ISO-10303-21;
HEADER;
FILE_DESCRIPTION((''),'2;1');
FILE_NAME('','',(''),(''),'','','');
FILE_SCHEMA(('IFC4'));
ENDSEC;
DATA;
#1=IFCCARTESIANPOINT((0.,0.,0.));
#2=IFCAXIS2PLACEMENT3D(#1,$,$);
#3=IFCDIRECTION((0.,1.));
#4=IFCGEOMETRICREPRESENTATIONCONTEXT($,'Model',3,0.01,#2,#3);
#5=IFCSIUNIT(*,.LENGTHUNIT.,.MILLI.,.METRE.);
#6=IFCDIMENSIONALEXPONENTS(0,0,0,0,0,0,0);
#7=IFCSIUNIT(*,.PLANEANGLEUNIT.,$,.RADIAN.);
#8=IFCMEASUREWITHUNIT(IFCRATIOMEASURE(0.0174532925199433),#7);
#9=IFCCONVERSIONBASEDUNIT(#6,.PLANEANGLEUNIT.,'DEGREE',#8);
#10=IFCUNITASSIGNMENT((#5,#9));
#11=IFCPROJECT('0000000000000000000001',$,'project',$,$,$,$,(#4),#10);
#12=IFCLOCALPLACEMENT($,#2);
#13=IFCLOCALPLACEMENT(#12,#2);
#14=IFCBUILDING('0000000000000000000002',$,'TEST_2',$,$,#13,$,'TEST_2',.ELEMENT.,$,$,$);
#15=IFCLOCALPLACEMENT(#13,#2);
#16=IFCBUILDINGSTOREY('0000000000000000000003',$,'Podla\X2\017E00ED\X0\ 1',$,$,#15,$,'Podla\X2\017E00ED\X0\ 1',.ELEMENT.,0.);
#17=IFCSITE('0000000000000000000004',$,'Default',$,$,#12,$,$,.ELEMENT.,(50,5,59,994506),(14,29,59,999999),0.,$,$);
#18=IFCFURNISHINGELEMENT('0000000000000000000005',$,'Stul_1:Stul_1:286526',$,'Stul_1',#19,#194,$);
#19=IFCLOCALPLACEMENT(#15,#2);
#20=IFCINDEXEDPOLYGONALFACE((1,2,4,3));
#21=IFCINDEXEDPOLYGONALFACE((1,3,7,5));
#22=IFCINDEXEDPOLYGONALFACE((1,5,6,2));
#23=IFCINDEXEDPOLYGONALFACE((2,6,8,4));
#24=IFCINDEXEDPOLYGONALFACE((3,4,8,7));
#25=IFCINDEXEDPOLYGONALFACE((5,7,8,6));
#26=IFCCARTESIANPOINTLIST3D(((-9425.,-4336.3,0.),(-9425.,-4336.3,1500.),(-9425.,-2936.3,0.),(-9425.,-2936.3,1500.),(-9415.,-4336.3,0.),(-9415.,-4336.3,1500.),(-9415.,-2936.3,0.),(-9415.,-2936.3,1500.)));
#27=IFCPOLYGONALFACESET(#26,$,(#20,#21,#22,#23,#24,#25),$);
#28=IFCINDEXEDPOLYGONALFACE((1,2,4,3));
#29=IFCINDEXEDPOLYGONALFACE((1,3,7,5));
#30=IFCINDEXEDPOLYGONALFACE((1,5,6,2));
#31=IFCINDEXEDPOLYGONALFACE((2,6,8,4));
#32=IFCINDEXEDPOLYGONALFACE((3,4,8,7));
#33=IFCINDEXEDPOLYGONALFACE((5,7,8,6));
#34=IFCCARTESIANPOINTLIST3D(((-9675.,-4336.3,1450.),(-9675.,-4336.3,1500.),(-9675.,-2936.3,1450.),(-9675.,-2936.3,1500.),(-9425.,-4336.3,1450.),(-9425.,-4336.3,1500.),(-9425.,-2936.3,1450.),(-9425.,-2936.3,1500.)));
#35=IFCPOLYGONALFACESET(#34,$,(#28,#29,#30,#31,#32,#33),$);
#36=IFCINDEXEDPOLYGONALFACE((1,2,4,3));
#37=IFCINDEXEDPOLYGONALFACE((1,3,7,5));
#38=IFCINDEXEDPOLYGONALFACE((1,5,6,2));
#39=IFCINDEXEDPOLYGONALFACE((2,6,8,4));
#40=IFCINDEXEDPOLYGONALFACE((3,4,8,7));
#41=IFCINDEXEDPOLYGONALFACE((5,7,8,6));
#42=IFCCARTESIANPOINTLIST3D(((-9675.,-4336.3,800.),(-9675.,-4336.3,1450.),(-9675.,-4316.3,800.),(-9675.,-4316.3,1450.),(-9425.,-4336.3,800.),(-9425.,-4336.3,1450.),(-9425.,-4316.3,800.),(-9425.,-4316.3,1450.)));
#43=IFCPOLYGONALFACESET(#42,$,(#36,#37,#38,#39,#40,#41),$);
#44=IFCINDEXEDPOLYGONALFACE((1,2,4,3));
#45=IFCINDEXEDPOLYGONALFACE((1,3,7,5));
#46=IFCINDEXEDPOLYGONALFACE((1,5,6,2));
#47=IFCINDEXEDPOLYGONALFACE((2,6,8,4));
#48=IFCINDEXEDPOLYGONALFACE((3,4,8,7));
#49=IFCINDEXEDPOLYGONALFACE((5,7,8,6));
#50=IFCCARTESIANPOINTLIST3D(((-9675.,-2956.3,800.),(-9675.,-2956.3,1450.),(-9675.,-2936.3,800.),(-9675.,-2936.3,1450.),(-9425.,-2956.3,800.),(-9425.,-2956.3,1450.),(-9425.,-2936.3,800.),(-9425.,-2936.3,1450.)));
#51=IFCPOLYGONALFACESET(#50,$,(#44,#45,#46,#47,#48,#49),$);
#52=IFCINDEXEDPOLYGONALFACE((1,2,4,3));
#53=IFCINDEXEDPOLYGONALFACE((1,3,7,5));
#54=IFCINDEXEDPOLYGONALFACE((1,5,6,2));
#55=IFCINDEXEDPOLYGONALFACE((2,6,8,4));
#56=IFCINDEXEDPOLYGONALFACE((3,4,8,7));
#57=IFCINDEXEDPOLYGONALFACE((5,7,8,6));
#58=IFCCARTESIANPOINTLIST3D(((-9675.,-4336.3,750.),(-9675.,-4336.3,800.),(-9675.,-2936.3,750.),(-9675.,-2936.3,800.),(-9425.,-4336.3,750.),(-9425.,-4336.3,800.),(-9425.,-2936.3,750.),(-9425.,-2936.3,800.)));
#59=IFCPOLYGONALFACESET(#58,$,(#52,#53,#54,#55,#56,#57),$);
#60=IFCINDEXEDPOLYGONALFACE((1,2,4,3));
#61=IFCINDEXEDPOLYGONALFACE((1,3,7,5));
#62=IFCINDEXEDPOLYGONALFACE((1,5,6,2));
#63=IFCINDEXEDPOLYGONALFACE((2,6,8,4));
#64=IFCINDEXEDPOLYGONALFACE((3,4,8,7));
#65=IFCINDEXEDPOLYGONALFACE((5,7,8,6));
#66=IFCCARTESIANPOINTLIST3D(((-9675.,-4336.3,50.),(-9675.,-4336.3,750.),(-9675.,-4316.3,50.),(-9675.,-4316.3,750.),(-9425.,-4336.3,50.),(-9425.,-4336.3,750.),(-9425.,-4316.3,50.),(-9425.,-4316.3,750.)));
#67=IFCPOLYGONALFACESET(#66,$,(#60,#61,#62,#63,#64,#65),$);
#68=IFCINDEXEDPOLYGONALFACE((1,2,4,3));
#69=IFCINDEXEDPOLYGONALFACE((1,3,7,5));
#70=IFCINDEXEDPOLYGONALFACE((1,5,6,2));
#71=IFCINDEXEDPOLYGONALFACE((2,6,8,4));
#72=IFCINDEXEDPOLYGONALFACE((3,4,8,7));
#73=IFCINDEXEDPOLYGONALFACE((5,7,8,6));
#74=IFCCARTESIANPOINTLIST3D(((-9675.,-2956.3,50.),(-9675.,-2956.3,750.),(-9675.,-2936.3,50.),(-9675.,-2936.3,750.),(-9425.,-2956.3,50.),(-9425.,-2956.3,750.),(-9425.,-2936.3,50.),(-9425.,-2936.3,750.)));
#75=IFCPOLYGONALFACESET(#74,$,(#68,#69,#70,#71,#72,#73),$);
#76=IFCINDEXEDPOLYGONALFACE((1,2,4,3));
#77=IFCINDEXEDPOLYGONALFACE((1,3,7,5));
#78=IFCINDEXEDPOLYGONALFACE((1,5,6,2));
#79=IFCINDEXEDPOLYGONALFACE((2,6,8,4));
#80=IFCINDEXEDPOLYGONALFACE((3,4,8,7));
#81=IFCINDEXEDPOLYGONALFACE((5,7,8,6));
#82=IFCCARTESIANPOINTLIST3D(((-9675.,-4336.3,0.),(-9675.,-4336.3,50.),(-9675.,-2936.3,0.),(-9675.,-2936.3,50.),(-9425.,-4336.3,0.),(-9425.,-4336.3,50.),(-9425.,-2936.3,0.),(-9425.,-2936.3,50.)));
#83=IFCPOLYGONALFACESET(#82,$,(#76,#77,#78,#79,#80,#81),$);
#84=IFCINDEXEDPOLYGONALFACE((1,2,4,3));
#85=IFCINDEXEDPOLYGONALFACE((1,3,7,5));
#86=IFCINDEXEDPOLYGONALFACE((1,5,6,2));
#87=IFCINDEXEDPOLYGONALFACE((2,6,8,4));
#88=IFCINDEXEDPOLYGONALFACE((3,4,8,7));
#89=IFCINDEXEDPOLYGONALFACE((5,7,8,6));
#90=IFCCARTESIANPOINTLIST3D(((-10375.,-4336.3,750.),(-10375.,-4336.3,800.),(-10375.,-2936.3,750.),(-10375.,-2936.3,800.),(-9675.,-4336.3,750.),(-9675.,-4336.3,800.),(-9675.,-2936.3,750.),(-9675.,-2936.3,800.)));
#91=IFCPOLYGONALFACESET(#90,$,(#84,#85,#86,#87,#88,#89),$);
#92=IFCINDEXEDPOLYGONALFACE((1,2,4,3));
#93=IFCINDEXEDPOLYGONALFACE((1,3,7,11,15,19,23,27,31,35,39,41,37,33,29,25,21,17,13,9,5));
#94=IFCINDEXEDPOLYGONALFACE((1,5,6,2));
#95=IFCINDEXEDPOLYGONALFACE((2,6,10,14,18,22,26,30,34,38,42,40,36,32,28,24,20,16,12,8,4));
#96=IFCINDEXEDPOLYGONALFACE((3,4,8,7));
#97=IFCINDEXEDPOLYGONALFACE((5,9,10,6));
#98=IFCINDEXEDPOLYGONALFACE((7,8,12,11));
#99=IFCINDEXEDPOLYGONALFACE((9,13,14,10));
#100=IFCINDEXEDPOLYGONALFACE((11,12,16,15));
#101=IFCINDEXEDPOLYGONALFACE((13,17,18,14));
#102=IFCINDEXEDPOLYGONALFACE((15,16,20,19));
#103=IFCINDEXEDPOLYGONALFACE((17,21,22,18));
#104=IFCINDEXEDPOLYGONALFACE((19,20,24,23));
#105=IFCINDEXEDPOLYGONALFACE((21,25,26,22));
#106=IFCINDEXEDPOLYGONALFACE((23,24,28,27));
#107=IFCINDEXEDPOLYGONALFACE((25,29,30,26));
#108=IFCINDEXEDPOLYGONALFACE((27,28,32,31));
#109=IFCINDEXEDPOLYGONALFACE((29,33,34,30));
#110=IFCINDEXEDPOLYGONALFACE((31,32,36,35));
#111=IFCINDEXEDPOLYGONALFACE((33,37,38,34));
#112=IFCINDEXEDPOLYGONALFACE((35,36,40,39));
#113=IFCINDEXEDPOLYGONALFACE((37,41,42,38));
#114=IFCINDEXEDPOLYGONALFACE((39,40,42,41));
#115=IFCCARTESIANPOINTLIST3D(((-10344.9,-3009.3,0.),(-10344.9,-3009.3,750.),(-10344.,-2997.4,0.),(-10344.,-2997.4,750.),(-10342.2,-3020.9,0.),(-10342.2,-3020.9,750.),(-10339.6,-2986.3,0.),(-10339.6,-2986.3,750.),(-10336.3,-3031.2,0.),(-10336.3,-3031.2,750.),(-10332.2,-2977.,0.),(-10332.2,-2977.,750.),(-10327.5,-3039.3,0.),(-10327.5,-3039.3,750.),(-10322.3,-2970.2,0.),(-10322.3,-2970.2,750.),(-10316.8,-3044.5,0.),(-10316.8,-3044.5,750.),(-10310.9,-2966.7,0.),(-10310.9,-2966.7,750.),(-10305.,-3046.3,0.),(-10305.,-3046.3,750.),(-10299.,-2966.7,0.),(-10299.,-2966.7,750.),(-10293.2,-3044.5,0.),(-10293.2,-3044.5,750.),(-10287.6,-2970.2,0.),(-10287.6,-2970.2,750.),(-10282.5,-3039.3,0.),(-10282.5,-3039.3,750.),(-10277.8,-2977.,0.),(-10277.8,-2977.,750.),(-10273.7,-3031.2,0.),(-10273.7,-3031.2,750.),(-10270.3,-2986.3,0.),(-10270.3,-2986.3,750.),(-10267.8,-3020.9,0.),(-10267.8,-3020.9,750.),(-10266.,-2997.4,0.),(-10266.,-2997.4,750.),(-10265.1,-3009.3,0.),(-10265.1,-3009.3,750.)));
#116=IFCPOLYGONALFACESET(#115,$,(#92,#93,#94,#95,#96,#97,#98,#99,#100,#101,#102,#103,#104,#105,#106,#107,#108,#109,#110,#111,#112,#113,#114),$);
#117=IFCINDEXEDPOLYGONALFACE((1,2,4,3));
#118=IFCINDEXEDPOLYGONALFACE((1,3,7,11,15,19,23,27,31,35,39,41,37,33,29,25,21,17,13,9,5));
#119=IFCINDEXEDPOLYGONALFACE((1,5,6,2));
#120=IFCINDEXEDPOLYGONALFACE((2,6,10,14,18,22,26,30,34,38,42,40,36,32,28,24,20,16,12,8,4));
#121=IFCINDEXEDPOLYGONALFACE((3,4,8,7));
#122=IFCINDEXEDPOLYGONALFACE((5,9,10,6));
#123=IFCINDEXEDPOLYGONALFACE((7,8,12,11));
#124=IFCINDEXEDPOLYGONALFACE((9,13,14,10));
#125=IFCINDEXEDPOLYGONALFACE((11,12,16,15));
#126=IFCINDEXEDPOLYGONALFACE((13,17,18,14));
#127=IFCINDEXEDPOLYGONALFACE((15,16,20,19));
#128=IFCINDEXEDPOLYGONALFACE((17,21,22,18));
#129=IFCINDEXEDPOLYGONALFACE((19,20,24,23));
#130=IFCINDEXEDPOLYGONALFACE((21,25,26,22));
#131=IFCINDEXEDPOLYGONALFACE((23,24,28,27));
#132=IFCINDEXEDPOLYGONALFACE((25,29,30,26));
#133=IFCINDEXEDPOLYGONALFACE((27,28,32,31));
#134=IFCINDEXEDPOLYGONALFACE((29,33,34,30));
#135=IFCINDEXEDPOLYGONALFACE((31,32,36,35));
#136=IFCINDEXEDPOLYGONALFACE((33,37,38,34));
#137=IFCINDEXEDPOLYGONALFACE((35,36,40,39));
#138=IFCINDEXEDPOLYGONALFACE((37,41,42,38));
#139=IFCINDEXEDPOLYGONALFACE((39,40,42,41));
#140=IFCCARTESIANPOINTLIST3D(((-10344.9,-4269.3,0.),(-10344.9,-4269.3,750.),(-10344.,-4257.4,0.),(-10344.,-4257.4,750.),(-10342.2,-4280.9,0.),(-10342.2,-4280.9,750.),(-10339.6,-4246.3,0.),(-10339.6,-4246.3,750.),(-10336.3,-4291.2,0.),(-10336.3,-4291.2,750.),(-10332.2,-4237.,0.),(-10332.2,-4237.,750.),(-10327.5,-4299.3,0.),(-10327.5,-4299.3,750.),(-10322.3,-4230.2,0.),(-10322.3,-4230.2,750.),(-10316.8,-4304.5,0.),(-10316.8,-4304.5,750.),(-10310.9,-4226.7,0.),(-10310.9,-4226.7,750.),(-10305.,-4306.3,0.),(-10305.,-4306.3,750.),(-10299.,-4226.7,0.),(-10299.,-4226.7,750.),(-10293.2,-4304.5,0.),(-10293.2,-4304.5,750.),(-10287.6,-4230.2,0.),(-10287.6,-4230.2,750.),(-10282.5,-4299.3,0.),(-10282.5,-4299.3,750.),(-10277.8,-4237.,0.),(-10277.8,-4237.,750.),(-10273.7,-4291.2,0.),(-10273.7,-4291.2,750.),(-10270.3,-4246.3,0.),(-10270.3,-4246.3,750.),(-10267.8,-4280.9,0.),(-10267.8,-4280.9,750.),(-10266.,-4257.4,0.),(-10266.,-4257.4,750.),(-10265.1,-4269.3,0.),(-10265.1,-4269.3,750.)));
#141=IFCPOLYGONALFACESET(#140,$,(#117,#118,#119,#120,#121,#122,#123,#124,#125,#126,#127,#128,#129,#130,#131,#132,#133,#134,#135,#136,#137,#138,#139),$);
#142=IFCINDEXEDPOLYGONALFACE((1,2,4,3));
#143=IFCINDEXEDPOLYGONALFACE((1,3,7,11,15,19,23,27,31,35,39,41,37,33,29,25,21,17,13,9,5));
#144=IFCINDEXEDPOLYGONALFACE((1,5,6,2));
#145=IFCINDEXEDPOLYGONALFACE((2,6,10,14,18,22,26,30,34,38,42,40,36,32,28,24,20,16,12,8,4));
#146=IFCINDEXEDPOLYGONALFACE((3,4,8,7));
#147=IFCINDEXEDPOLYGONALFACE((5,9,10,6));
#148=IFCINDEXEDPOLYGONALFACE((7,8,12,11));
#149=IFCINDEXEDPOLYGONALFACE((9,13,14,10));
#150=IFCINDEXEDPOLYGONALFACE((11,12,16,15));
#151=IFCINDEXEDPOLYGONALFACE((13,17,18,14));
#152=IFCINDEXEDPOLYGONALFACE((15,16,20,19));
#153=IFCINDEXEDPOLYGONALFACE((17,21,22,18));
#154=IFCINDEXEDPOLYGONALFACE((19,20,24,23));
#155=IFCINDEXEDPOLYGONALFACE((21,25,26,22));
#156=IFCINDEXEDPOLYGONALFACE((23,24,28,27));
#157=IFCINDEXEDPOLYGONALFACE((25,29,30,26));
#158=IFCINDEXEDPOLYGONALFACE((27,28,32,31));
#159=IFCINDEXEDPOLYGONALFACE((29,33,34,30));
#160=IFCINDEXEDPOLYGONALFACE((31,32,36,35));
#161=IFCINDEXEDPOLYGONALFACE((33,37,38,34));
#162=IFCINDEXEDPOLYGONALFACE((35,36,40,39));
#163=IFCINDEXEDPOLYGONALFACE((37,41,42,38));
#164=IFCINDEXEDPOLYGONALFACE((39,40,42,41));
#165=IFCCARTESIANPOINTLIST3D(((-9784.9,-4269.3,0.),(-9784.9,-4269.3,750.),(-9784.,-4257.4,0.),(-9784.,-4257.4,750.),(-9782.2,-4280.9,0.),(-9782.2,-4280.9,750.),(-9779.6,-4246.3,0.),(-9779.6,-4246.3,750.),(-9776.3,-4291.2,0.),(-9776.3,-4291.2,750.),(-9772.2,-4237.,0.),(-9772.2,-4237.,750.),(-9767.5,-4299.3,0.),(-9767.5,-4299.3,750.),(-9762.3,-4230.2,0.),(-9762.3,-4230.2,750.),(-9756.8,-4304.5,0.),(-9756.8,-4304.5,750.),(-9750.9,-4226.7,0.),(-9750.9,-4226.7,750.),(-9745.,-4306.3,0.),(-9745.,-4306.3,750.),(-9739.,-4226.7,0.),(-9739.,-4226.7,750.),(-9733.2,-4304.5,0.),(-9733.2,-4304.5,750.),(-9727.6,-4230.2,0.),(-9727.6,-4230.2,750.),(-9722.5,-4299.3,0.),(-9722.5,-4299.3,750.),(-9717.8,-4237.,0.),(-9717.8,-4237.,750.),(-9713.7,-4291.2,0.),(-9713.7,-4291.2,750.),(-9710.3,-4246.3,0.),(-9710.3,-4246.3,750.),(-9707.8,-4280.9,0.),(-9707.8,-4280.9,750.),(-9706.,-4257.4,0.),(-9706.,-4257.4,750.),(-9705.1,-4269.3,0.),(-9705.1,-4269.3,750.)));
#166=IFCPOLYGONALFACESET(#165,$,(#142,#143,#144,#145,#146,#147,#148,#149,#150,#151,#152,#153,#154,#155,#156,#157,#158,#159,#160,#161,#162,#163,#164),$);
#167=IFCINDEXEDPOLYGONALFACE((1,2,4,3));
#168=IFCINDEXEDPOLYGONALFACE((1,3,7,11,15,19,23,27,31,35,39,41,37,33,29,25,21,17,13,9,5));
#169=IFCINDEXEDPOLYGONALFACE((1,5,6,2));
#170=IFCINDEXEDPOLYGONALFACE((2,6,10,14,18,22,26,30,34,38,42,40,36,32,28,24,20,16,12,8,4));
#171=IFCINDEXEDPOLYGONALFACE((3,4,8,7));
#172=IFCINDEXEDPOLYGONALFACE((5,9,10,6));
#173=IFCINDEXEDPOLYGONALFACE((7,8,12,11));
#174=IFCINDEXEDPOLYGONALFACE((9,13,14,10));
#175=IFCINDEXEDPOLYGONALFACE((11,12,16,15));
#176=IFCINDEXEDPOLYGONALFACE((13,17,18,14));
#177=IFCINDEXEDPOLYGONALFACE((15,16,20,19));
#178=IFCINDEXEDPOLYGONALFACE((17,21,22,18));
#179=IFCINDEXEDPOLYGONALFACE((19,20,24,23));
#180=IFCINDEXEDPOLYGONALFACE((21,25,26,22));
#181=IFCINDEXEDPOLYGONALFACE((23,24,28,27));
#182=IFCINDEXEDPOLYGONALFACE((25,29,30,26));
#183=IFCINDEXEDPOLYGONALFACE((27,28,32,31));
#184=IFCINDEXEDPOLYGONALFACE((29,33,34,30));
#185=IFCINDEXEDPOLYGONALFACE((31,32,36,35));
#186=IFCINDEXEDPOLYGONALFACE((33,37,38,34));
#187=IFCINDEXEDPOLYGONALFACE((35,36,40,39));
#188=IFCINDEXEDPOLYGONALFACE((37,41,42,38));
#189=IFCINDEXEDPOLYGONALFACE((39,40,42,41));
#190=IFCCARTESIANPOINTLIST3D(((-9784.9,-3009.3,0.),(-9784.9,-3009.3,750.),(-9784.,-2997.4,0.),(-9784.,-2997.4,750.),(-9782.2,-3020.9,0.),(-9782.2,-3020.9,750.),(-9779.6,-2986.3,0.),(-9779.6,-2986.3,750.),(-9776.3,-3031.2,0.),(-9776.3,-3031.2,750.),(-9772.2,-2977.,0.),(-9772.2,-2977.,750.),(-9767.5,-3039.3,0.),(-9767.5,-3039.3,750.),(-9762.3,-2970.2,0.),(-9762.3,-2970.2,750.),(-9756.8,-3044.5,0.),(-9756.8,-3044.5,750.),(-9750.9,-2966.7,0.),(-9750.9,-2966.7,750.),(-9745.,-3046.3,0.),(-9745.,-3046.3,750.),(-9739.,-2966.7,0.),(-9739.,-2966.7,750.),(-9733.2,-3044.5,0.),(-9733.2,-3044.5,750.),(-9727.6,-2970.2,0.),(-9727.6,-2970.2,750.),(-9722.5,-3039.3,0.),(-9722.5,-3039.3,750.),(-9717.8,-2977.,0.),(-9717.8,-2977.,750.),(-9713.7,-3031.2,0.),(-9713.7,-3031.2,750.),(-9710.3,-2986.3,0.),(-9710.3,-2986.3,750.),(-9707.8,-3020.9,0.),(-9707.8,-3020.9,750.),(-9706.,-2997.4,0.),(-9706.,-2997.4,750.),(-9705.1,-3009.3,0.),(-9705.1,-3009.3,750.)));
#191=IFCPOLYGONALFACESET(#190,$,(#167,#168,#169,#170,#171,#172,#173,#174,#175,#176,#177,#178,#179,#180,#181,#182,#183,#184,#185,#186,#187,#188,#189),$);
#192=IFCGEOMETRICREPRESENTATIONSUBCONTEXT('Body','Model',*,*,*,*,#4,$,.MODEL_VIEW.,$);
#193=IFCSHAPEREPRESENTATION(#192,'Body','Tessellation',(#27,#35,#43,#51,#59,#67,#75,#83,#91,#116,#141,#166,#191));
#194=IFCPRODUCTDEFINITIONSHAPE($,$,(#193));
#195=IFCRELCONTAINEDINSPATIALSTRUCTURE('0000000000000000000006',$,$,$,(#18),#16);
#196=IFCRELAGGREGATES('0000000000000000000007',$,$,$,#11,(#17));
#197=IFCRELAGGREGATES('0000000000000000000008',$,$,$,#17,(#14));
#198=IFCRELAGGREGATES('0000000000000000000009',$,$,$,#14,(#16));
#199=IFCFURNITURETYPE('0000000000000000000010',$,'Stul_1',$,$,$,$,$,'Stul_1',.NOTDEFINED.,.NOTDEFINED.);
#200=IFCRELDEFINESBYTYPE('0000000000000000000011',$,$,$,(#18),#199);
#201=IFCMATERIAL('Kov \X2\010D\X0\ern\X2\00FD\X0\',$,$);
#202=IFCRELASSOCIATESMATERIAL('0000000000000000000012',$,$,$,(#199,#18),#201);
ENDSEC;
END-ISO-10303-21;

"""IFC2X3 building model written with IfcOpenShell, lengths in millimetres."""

from ifc_helpers import new_model, entity, si_unit, converted_unit, direction, frame, frame_2d, origin, origin_2d_with_axis, place, context, subcontext, project, spatial, rectangle, circle, extrude, source, transform, mapped, material, type_object, type_shapes, element, save


model = new_model("IFC2X3")

# Units and contexts
model_context = context("Model", 3, precision=0.01, world=origin(), true_north=direction((0.0, 1.0)))
body_context = subcontext(model_context, "Body", "Model", "MODEL_VIEW")
ifc_project = project(units=[si_unit("LENGTHUNIT", "METRE", prefix="MILLI"), converted_unit("PLANEANGLEUNIT", "DEGREE", entity("IfcRatioMeasure", 0.0174532925199433), si_unit("PLANEANGLEUNIT", "RADIAN"), dimensions=[0, 0, 0, 0, 0, 0, 0])], contexts=[model_context])

# Site, building, storey
site_placement = place(None, origin())
site = spatial("IfcSite", under=ifc_project, at=site_placement, Name="Default", CompositionType="ELEMENT", RefLatitude=(50, 5, 59, 994506), RefLongitude=(14, 29, 59, 999999), RefElevation=0.0)
building_placement = place(site_placement, origin())
building = spatial("IfcBuilding", under=site, at=building_placement, Name="TEST_2", LongName="TEST_2", CompositionType="ELEMENT")
storey_placement = place(building_placement, origin())
storey = spatial("IfcBuildingStorey", under=building, at=storey_placement, Name="Podlaží 1", LongName="Podlaží 1", CompositionType="ELEMENT", Elevation=0.0)

# Furnishing element
ifc_material_1 = material(Name="Kov černý")
furniture_type = type_object("IfcFurnitureType", Name="Stul_1", ElementType="Stul_1", material=ifc_material_1)
shared_shape_1 = source(origin(), body_context, "Body", "SweptSolid", [
    extrude(rectangle(XDim=1400.0, YDim=10.0, at=origin_2d_with_axis()), frame((0.0, 605.0, 0.0), z_axis=(0.0, 0.0, 1.0), x_axis=(-1.0, 0.0, 0.0)), (0.0, 0.0, 1.0), 1500.0),
    extrude(rectangle(XDim=1400.0, YDim=250.0, at=frame_2d((0.0, 0.0), x_axis=(1.0, 0.0))), frame((0.0, 475.0, 1450.0), z_axis=(0.0, 0.0, 1.0), x_axis=(-1.0, 0.0, 0.0)), (0.0, 0.0, 1.0), 50.0),
    extrude(rectangle(XDim=20.0, YDim=250.0, at=origin_2d_with_axis()), frame((690.0, 475.0, 800.0), z_axis=(0.0, 0.0, 1.0), x_axis=(-1.0, 0.0, 0.0)), (0.0, 0.0, 1.0), 650.0),
    extrude(rectangle(XDim=20.0, YDim=250.0, at=frame_2d((0.0, 0.0), x_axis=(1.0, 0.0))), frame((-690.0, 475.0, 800.0), z_axis=(0.0, 0.0, 1.0), x_axis=(-1.0, 0.0, 0.0)), (0.0, 0.0, 1.0), 650.0),
    extrude(rectangle(XDim=1400.0, YDim=250.0, at=origin_2d_with_axis()), frame((0.0, 475.0, 750.0), z_axis=(0.0, 0.0, 1.0), x_axis=(-1.0, 0.0, 0.0)), (0.0, 0.0, 1.0), 50.0),
    extrude(rectangle(XDim=20.0, YDim=250.0, at=origin_2d_with_axis()), frame((690.0, 475.0, 50.0), z_axis=(0.0, 0.0, 1.0), x_axis=(-1.0, 0.0, 0.0)), (0.0, 0.0, 1.0), 700.0),
    extrude(rectangle(XDim=20.0, YDim=250.0, at=frame_2d((0.0, 0.0), x_axis=(1.0, 0.0))), frame((-690.0, 475.0, 50.0), z_axis=(0.0, 0.0, 1.0), x_axis=(-1.0, 0.0, 0.0)), (0.0, 0.0, 1.0), 700.0),
    extrude(rectangle(XDim=1400.0, YDim=250.0, at=origin_2d_with_axis()), frame((0.0, 475.0, 0.0), z_axis=(0.0, 0.0, 1.0), x_axis=(-1.0, 0.0, 0.0)), (0.0, 0.0, 1.0), 50.0),
    extrude(rectangle(XDim=1400.0, YDim=700.0, at=origin_2d_with_axis()), frame((0.0, 0.0, 750.0), z_axis=(0.0, 0.0, 1.0), x_axis=(-1.0, 0.0, 0.0)), (0.0, 0.0, 1.0), 50.0),
    extrude(circle(Radius=40.0, at=frame_2d((0.0, 0.0), x_axis=(1.0, 0.0))), frame((-630.0, -280.0, 0.0)), (0.0, 0.0, 1.0), 750.0),
    extrude(circle(Radius=40.0, at=frame_2d((0.0, 0.0), x_axis=(1.0, 0.0))), frame((630.0, -280.0, 0.0)), (0.0, 0.0, 1.0), 750.0),
    extrude(circle(Radius=40.0, at=frame_2d((0.0, 0.0), x_axis=(1.0, 0.0))), frame((630.0, 280.0, 0.0)), (0.0, 0.0, 1.0), 750.0),
    extrude(circle(Radius=40.0, at=frame_2d((0.0, 0.0), x_axis=(1.0, 0.0))), frame((-630.0, 280.0, 0.0)), (0.0, 0.0, 1.0), 750.0),
])
type_shapes(furniture_type, [shared_shape_1])
for number, where, z_axis, x_axis, name in (
    (1, (-10025.0, -3636.3, 0.0), (0.0, 0.0, 1.0), (0.0, -1.0, 0.0), "Stul_1:Stul_1:286526"),
):
    element("IfcFurnishingElement", number, at=place(storey_placement, frame(where, z_axis=z_axis, x_axis=x_axis)), inside=storey, type_object=furniture_type, material=ifc_material_1, Name=name, ObjectType="Stul_1", context=body_context, shape_type="MappedRepresentation", body=[
        mapped(shared_shape_1, transform((0.0, 0.0, 0.0), scale=1.0)),
    ])

save(model, "model.ifc")
